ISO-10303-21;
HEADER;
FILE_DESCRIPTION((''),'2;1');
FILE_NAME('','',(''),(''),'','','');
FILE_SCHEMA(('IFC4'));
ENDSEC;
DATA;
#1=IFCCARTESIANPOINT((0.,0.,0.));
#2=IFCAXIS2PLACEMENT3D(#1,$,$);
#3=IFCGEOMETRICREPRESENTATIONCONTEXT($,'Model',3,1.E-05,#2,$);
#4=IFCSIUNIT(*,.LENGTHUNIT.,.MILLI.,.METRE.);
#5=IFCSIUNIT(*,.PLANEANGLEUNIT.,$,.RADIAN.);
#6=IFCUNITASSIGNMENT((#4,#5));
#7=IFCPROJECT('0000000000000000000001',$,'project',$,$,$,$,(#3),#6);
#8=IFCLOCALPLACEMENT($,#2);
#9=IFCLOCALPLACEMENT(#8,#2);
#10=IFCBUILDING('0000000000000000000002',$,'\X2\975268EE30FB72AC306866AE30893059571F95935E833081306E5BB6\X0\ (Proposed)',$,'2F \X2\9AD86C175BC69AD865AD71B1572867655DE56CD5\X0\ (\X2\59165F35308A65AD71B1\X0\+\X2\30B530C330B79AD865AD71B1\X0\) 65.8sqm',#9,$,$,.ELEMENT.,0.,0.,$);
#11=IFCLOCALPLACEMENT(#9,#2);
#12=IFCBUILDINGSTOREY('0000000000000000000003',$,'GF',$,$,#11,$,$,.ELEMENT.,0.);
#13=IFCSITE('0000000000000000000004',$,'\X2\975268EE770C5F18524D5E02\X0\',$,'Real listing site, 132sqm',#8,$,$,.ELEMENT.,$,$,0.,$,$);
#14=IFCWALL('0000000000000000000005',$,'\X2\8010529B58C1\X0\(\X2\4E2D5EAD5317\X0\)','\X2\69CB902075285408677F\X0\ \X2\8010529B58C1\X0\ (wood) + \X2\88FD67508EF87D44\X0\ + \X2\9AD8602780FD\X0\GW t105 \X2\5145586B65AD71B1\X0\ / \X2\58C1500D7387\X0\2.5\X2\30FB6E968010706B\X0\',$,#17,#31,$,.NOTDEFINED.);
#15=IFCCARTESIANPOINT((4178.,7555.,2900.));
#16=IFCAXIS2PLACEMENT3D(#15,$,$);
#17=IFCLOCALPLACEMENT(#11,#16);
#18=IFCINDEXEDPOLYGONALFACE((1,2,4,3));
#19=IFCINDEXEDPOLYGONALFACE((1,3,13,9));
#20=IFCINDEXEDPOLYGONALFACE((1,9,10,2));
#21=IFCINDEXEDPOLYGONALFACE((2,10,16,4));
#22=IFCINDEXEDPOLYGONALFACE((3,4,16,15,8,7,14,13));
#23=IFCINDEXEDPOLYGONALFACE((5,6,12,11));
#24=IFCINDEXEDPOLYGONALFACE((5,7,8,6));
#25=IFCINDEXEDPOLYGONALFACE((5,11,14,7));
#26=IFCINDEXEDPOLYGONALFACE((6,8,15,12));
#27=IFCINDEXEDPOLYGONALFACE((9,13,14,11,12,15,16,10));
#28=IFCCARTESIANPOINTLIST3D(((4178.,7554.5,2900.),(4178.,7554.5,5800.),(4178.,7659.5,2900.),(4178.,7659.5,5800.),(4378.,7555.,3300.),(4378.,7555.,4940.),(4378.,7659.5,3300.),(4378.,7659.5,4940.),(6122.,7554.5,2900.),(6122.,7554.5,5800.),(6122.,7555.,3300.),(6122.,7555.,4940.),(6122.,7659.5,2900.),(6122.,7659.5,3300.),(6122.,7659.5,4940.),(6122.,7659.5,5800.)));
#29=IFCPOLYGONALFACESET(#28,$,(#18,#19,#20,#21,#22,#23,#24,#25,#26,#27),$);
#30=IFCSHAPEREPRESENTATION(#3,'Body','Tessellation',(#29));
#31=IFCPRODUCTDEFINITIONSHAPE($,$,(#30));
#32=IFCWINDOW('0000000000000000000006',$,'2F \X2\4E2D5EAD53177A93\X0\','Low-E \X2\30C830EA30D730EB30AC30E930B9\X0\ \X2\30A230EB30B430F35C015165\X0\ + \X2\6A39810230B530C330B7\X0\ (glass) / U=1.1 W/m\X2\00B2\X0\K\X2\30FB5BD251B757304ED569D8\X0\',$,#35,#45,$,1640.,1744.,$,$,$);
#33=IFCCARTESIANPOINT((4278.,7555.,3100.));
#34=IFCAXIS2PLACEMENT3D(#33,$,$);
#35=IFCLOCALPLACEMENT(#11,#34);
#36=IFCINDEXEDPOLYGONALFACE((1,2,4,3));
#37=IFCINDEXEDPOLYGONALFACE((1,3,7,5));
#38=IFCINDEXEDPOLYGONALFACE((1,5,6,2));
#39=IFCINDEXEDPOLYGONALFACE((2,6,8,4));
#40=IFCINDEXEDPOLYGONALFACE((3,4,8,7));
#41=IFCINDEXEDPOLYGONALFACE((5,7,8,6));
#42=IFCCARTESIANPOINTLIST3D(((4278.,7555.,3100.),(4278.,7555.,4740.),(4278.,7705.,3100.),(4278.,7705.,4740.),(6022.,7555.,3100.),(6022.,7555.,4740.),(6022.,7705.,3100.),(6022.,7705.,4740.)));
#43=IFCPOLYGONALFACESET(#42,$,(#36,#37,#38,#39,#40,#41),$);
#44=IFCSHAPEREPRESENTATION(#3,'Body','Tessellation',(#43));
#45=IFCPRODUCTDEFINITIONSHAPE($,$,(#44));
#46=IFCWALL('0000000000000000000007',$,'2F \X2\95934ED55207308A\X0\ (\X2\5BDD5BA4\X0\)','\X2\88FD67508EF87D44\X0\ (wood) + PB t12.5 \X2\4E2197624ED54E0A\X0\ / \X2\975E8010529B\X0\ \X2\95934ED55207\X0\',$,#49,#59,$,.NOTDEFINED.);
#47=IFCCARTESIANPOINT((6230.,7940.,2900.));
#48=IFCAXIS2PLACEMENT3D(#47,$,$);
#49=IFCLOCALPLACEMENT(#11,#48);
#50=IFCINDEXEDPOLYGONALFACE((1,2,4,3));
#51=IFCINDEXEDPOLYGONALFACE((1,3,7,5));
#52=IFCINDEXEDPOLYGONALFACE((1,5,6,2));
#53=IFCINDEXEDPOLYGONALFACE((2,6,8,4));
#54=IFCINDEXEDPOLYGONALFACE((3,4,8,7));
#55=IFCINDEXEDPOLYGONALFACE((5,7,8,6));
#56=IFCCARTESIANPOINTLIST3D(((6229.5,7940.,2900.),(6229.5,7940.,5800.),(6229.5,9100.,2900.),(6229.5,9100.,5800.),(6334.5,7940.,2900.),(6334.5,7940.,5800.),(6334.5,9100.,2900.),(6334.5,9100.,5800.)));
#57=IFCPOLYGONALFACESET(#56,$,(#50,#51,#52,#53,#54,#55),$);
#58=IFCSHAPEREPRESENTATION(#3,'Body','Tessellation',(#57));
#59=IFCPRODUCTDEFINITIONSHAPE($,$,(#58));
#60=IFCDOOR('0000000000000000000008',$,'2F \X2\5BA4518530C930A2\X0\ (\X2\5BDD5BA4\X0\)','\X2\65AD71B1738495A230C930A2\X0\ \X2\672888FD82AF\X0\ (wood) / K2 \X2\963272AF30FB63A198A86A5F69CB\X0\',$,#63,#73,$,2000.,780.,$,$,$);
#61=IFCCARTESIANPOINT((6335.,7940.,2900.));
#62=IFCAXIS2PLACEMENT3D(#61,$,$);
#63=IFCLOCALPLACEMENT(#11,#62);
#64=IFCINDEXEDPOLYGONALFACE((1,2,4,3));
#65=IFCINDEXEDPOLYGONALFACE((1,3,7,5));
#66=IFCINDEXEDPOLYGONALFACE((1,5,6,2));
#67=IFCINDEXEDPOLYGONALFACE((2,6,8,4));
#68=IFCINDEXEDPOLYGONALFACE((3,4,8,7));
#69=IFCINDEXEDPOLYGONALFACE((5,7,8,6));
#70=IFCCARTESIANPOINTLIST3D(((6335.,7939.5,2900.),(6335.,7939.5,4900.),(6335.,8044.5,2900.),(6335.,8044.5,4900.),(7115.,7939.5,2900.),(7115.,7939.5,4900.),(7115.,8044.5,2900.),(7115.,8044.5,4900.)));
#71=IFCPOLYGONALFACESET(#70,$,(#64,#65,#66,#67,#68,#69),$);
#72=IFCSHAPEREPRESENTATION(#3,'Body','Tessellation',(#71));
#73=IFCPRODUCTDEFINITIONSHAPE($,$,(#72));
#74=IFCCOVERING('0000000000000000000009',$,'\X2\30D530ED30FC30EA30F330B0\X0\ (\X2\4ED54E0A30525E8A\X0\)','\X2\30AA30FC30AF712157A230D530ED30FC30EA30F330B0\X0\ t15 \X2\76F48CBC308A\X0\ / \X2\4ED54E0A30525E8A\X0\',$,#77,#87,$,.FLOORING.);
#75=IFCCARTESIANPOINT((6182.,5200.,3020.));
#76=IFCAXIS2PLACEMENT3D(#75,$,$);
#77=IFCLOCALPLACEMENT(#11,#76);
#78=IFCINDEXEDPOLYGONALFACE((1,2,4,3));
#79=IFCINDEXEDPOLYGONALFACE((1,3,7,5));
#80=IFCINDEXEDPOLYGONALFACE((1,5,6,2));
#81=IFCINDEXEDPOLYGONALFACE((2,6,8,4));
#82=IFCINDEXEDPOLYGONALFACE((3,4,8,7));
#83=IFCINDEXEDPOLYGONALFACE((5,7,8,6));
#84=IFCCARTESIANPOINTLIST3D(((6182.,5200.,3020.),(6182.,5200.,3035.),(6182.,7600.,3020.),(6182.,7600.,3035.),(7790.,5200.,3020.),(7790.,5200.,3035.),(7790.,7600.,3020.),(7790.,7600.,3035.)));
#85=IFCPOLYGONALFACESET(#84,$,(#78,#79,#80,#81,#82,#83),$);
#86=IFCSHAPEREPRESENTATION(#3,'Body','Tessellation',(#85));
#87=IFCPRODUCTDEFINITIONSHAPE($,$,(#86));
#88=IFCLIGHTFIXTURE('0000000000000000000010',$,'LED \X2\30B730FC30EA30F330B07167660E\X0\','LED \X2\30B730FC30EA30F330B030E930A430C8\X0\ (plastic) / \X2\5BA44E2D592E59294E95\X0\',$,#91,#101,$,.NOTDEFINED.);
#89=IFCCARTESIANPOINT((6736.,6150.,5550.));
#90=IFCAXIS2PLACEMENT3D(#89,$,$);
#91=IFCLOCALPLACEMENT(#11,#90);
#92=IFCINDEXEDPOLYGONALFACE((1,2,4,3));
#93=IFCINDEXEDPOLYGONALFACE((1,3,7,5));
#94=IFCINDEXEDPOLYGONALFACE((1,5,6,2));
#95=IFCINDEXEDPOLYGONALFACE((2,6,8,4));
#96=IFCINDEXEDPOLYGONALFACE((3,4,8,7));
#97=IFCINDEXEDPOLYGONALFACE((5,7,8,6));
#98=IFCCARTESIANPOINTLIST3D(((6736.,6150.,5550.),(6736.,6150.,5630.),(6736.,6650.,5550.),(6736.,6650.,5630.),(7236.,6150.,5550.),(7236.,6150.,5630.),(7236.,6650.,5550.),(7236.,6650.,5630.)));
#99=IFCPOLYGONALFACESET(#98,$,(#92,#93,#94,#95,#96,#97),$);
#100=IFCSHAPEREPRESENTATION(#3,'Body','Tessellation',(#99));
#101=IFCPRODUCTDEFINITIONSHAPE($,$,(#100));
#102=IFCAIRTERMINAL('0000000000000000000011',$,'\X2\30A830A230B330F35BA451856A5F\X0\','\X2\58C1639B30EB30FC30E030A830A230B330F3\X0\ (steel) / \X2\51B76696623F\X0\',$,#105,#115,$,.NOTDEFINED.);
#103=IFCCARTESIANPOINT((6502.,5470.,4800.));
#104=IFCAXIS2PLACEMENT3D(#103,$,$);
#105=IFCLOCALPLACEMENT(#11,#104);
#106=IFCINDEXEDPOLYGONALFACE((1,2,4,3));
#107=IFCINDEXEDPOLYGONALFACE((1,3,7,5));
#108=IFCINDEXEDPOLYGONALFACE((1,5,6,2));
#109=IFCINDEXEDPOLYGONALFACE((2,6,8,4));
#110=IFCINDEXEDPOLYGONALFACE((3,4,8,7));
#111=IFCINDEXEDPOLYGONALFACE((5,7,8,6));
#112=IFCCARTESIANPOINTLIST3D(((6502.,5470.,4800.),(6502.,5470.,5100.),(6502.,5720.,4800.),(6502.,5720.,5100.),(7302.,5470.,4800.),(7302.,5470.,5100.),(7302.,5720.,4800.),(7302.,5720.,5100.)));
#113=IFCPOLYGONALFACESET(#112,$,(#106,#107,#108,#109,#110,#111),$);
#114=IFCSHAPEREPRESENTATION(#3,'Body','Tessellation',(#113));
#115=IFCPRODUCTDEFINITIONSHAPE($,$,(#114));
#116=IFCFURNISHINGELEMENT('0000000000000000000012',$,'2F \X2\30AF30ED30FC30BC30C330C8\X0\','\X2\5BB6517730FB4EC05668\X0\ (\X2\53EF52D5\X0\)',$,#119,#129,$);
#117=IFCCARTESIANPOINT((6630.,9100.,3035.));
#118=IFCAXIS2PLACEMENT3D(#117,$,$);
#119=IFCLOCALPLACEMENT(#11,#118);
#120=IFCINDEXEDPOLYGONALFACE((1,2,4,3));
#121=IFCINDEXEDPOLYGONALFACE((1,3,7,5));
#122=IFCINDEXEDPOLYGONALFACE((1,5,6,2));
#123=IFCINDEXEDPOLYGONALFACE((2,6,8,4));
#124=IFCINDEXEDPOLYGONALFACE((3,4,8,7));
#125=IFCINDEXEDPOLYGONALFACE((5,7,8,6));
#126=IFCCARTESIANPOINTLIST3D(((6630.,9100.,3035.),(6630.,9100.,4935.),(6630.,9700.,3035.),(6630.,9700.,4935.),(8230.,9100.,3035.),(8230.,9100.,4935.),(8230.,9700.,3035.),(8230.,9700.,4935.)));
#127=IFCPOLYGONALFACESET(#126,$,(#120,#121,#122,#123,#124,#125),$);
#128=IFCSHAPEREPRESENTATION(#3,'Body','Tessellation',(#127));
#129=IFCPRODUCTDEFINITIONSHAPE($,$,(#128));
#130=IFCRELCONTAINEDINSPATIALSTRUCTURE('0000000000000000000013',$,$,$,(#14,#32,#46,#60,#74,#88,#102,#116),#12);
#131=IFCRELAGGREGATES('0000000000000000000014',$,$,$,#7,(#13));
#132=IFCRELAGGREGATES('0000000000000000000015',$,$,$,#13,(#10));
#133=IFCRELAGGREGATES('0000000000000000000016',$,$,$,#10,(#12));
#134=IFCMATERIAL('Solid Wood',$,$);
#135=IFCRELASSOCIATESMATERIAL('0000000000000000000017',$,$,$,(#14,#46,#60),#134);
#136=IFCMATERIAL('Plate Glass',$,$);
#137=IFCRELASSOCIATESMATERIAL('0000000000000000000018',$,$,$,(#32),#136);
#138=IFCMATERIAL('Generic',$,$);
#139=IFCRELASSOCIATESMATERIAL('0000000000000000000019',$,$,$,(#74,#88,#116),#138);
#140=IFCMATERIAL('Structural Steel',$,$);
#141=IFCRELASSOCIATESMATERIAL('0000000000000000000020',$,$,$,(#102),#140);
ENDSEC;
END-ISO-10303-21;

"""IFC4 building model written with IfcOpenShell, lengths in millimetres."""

from ifc_helpers import new_model, si_unit, frame, frame_2d, origin, place, context, project, spatial, rectangle, extrude, material, element, fill, save


model = new_model("IFC4")

# Units and contexts
model_context = context("Model", 3, precision=1e-05, world=origin())
ifc_project = project(units=[si_unit("LENGTHUNIT", "METRE", prefix="MILLI"), si_unit("PLANEANGLEUNIT", "RADIAN")], contexts=[model_context])

# Site, building, storey
site_placement = place(None, origin())
site = spatial("IfcSite", under=ifc_project, at=site_placement, Name="青森県弘前市", ObjectType="Real listing site, 132sqm", CompositionType="ELEMENT", RefElevation=0.0)
building_placement = place(site_placement, origin())
building = spatial("IfcBuilding", under=site, at=building_placement, Name="青森・犬と暮らす土間広めの家 (Proposed)", ObjectType="2F 高気密高断熱在来工法 (外張り断熱+サッシ高断熱) 65.8sqm", CompositionType="ELEMENT", ElevationOfRefHeight=0.0, ElevationOfTerrain=0.0)
storey_placement = place(building_placement, origin())
storey = spatial("IfcBuildingStorey", under=building, at=storey_placement, Name="GF", CompositionType="ELEMENT", Elevation=0.0)

# Shared definitions
ifc_material_1 = material(Name="Solid Wood")

# Wall, opening, window
wall_1_placement = place(storey_placement, frame((4178.0, 7555.0, 2900.0)))
wall_1 = element("IfcWall", 1, at=wall_1_placement, inside=storey, material=ifc_material_1, Name="耐力壁(中庭北)", Description="構造用合板 耐力壁 (wood) + 製材軸組 + 高性能GW t105 充填断熱 / 壁倍率2.5・準耐火", PredefinedType="NOTDEFINED", context=model_context, shape_type="SweptSolid", body=[
    extrude(rectangle(XDim=1944.0, YDim=105.0, at=frame_2d((972.0, 52.0))), frame((4178.0, 7555.0, 2900.0)), (0.0, 0.0, 1.0), 2900.0),
])
opening_placement = place(storey_placement, frame((4278.0, 7555.0, 3100.0)))
opening = element("IfcOpeningElement", 2, at=opening_placement, cuts=wall_1, PredefinedType="NOTDEFINED", context=model_context, shape_type="SweptSolid", body=[
    extrude(rectangle(XDim=1744.0, YDim=150.0, at=frame_2d((872.0, 75.0))), frame((4278.0, 7555.0, 3100.0)), (0.0, 0.0, 1.0), 1640.0),
])
ifc_material_2 = material(Name="Plate Glass")
window_placement = place(storey_placement, frame((4278.0, 7555.0, 3100.0)))
window = element("IfcWindow", 3, at=window_placement, inside=storey, material=ifc_material_2, Name="2F 中庭北窓", Description="Low-E トリプルガラス アルゴン封入 + 樹脂サッシ (glass) / U=1.1 W/m²K・寒冷地仕様", OverallHeight=1640.0, OverallWidth=1744.0, context=model_context, shape_type="SweptSolid", body=[
    extrude(rectangle(XDim=1744.0, YDim=150.0, at=frame_2d((872.0, 75.0))), frame((4278.0, 7555.0, 3100.0)), (0.0, 0.0, 1.0), 1640.0),
])
fill(opening, window)

# Wall
wall_2_placement = place(storey_placement, frame((6230.0, 7940.0, 2900.0)))
element("IfcWall", 4, at=wall_2_placement, inside=storey, material=ifc_material_1, Name="2F 間仕切り (寝室)", Description="製材軸組 (wood) + PB t12.5 両面仕上 / 非耐力 間仕切", PredefinedType="NOTDEFINED", context=model_context, shape_type="SweptSolid", body=[
    extrude(rectangle(XDim=105.0, YDim=1160.0, at=frame_2d((52.0, 580.0))), frame((6230.0, 7940.0, 2900.0)), (0.0, 0.0, 1.0), 2900.0),
])

# Door
door_placement = place(storey_placement, frame((6335.0, 7940.0, 2900.0)))
element("IfcDoor", 5, at=door_placement, inside=storey, material=ifc_material_1, Name="2F 室内ドア (寝室)", Description="断熱玄関ドア 木製芯 (wood) / K2 防犯・採風機構", OverallHeight=2000.0, OverallWidth=780.0, context=model_context, shape_type="SweptSolid", body=[
    extrude(rectangle(XDim=780.0, YDim=105.0, at=frame_2d((390.0, 52.0))), frame((6335.0, 7940.0, 2900.0)), (0.0, 0.0, 1.0), 2000.0),
])

# Covering
ifc_material_3 = material(Name="Generic")
covering_placement = place(storey_placement, frame((6182.0, 5200.0, 3020.0)))
element("IfcCovering", 6, at=covering_placement, inside=storey, material=ifc_material_3, Name="フローリング (仕上げ床)", Description="オーク無垢フローリング t15 直貼り / 仕上げ床", PredefinedType="FLOORING", context=model_context, shape_type="SweptSolid", body=[
    extrude(rectangle(XDim=1608.0, YDim=2400.0, at=frame_2d((804.0, 1200.0))), frame((6182.0, 5200.0, 3020.0)), (0.0, 0.0, 1.0), 15.0),
])

# Light fixture
light_fixture_placement = place(storey_placement, frame((6736.0, 6150.0, 5550.0)))
element("IfcLightFixture", 7, at=light_fixture_placement, inside=storey, material=ifc_material_3, Name="LED シーリング照明", Description="LED シーリングライト (plastic) / 室中央天井", PredefinedType="NOTDEFINED", context=model_context, shape_type="SweptSolid", body=[
    extrude(rectangle(XDim=500.0, YDim=500.0, at=frame_2d((250.0, 250.0))), frame((6736.0, 6150.0, 5550.0)), (0.0, 0.0, 1.0), 80.0),
])

# Air terminal
ifc_material_4 = material(Name="Structural Steel")
air_terminal_placement = place(storey_placement, frame((6502.0, 5470.0, 4800.0)))
element("IfcAirTerminal", 8, at=air_terminal_placement, inside=storey, material=ifc_material_4, Name="エアコン室内機", Description="壁掛ルームエアコン (steel) / 冷暖房", PredefinedType="NOTDEFINED", context=model_context, shape_type="SweptSolid", body=[
    extrude(rectangle(XDim=800.0, YDim=250.0, at=frame_2d((400.0, 125.0))), frame((6502.0, 5470.0, 4800.0)), (0.0, 0.0, 1.0), 300.0),
])

# Furnishing element
furnishing_placement = place(storey_placement, frame((6630.0, 9100.0, 3035.0)))
element("IfcFurnishingElement", 9, at=furnishing_placement, inside=storey, material=ifc_material_3, Name="2F クローゼット", Description="家具・什器 (可動)", context=model_context, shape_type="SweptSolid", body=[
    extrude(rectangle(XDim=1600.0, YDim=600.0, at=frame_2d((800.0, 300.0))), frame((6630.0, 9100.0, 3035.0)), (0.0, 0.0, 1.0), 1900.0),
])

save(model, "model.ifc")
